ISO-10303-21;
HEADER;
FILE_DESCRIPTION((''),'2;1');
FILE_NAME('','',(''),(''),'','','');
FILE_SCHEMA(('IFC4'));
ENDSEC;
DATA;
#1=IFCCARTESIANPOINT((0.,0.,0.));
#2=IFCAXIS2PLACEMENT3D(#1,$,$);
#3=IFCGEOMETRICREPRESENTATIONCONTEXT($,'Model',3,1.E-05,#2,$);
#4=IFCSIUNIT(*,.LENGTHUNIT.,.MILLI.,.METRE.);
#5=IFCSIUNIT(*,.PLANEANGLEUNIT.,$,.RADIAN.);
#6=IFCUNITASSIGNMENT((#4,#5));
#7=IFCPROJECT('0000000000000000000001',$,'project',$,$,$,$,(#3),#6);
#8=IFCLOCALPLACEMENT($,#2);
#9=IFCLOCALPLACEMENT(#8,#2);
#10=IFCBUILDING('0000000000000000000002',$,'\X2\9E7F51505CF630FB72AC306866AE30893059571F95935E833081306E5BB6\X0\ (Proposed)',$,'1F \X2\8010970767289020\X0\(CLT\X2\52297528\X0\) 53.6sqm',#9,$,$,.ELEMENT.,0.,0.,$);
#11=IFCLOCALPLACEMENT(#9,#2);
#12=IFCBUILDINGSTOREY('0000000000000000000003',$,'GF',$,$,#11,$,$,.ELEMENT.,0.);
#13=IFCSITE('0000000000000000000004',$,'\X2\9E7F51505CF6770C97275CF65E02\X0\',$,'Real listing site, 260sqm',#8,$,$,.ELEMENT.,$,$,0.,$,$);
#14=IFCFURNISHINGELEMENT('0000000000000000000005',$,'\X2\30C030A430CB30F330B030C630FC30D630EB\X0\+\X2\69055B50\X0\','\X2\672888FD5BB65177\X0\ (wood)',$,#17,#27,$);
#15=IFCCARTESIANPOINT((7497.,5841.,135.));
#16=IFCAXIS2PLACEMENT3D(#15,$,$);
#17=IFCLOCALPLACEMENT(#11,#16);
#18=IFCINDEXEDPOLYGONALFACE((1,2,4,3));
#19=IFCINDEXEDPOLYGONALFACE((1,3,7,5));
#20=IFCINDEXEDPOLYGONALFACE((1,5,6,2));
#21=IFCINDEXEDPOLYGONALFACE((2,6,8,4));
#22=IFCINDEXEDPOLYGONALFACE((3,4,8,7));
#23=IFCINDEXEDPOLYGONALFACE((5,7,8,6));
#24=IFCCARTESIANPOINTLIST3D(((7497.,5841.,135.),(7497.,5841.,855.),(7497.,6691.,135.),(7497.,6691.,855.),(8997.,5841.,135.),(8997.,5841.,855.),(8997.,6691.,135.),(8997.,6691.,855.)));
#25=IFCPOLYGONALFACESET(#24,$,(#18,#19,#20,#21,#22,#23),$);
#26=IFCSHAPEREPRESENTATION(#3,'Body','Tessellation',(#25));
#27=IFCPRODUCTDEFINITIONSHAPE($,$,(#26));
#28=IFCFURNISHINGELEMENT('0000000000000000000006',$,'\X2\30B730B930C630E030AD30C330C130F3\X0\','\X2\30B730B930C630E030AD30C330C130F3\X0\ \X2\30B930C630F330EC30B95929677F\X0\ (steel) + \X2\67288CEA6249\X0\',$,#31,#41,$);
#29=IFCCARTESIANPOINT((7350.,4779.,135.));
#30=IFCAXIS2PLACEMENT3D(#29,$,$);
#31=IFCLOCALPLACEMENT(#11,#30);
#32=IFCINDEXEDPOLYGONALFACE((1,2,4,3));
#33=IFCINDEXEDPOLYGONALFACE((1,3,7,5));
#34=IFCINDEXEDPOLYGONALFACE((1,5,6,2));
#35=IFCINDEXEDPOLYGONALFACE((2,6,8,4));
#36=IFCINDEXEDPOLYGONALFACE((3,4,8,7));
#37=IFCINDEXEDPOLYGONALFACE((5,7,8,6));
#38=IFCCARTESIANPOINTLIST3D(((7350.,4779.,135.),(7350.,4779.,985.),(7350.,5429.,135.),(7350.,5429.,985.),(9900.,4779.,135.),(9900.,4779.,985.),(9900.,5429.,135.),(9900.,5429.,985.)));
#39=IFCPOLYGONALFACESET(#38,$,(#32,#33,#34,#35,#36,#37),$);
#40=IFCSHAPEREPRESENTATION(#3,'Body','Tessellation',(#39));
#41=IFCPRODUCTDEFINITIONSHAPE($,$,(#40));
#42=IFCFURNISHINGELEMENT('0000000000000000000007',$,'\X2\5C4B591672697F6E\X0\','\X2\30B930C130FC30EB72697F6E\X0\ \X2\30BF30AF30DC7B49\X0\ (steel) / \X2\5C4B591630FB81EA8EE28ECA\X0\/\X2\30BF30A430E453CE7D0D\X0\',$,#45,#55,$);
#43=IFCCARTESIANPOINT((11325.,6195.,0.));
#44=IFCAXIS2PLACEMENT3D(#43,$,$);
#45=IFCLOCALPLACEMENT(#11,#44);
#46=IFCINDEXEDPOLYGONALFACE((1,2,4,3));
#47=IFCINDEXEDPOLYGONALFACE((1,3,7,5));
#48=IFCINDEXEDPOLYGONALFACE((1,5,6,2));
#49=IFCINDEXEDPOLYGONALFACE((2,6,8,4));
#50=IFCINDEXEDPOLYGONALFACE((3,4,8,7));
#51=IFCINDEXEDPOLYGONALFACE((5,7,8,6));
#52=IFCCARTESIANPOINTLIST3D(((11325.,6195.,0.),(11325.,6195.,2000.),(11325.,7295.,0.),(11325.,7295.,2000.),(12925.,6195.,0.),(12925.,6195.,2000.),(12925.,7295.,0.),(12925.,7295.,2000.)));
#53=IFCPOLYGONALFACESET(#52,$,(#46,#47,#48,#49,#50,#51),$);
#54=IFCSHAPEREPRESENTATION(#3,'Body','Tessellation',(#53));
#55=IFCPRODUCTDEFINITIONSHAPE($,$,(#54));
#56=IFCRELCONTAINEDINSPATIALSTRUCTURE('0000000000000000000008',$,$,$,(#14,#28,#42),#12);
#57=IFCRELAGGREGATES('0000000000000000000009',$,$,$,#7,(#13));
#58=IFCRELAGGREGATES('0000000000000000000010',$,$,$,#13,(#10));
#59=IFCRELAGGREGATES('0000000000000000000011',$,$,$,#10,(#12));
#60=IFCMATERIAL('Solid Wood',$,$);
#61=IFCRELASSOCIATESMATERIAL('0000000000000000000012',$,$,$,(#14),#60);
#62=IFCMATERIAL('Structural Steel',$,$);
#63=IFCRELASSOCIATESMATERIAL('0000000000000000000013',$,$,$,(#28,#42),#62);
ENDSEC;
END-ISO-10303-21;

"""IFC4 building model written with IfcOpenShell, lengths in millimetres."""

from ifc_helpers import new_model, si_unit, frame, frame_2d, origin, place, context, project, spatial, rectangle, extrude, material, element, save


model = new_model("IFC4")

# Units and contexts
model_context = context("Model", 3, precision=1e-05, world=origin())
ifc_project = project(units=[si_unit("LENGTHUNIT", "METRE", prefix="MILLI"), si_unit("PLANEANGLEUNIT", "RADIAN")], contexts=[model_context])

# Site, building, storey
site_placement = place(None, origin())
site = spatial("IfcSite", under=ifc_project, at=site_placement, Name="鹿児島県霧島市", ObjectType="Real listing site, 260sqm", CompositionType="ELEMENT", RefElevation=0.0)
building_placement = place(site_placement, origin())
building = spatial("IfcBuilding", under=site, at=building_placement, Name="鹿児島・犬と暮らす土間広めの家 (Proposed)", ObjectType="1F 耐震木造(CLT利用) 53.6sqm", CompositionType="ELEMENT", ElevationOfRefHeight=0.0, ElevationOfTerrain=0.0)
storey_placement = place(building_placement, origin())
storey = spatial("IfcBuildingStorey", under=building, at=storey_placement, Name="GF", CompositionType="ELEMENT", Elevation=0.0)

# Shared definitions
ifc_material_1 = material(Name="Solid Wood")

# Shared definitions
ifc_material_2 = material(Name="Structural Steel")

# Furnishing elements
furnishing_1_placement = place(storey_placement, frame((7497.0, 5841.0, 135.0)))
element("IfcFurnishingElement", 1, at=furnishing_1_placement, inside=storey, material=ifc_material_1, Name="ダイニングテーブル+椅子", Description="木製家具 (wood)", context=model_context, shape_type="SweptSolid", body=[
    extrude(rectangle(XDim=1500.0, YDim=850.0, at=frame_2d((750.0, 425.0))), frame((7497.0, 5841.0, 135.0)), (0.0, 0.0, 1.0), 720.0),
])
furnishing_2_placement = place(storey_placement, frame((7350.0, 4779.0, 135.0)))
element("IfcFurnishingElement", 2, at=furnishing_2_placement, inside=storey, material=ifc_material_2, Name="システムキッチン", Description="システムキッチン ステンレス天板 (steel) + 木質扉", context=model_context, shape_type="SweptSolid", body=[
    extrude(rectangle(XDim=2550.0, YDim=650.0, at=frame_2d((1275.0, 325.0))), frame((7350.0, 4779.0, 135.0)), (0.0, 0.0, 1.0), 850.0),
])
furnishing_3_placement = place(storey_placement, frame((11325.0, 6195.0, 0.0)))
element("IfcFurnishingElement", 3, at=furnishing_3_placement, inside=storey, material=ifc_material_2, Name="屋外物置", Description="スチール物置 タクボ等 (steel) / 屋外・自転車/タイヤ収納", context=model_context, shape_type="SweptSolid", body=[
    extrude(rectangle(XDim=1600.0, YDim=1100.0, at=frame_2d((800.0, 550.0))), frame((11325.0, 6195.0, 0.0)), (0.0, 0.0, 1.0), 2000.0),
])

save(model, "model.ifc")
